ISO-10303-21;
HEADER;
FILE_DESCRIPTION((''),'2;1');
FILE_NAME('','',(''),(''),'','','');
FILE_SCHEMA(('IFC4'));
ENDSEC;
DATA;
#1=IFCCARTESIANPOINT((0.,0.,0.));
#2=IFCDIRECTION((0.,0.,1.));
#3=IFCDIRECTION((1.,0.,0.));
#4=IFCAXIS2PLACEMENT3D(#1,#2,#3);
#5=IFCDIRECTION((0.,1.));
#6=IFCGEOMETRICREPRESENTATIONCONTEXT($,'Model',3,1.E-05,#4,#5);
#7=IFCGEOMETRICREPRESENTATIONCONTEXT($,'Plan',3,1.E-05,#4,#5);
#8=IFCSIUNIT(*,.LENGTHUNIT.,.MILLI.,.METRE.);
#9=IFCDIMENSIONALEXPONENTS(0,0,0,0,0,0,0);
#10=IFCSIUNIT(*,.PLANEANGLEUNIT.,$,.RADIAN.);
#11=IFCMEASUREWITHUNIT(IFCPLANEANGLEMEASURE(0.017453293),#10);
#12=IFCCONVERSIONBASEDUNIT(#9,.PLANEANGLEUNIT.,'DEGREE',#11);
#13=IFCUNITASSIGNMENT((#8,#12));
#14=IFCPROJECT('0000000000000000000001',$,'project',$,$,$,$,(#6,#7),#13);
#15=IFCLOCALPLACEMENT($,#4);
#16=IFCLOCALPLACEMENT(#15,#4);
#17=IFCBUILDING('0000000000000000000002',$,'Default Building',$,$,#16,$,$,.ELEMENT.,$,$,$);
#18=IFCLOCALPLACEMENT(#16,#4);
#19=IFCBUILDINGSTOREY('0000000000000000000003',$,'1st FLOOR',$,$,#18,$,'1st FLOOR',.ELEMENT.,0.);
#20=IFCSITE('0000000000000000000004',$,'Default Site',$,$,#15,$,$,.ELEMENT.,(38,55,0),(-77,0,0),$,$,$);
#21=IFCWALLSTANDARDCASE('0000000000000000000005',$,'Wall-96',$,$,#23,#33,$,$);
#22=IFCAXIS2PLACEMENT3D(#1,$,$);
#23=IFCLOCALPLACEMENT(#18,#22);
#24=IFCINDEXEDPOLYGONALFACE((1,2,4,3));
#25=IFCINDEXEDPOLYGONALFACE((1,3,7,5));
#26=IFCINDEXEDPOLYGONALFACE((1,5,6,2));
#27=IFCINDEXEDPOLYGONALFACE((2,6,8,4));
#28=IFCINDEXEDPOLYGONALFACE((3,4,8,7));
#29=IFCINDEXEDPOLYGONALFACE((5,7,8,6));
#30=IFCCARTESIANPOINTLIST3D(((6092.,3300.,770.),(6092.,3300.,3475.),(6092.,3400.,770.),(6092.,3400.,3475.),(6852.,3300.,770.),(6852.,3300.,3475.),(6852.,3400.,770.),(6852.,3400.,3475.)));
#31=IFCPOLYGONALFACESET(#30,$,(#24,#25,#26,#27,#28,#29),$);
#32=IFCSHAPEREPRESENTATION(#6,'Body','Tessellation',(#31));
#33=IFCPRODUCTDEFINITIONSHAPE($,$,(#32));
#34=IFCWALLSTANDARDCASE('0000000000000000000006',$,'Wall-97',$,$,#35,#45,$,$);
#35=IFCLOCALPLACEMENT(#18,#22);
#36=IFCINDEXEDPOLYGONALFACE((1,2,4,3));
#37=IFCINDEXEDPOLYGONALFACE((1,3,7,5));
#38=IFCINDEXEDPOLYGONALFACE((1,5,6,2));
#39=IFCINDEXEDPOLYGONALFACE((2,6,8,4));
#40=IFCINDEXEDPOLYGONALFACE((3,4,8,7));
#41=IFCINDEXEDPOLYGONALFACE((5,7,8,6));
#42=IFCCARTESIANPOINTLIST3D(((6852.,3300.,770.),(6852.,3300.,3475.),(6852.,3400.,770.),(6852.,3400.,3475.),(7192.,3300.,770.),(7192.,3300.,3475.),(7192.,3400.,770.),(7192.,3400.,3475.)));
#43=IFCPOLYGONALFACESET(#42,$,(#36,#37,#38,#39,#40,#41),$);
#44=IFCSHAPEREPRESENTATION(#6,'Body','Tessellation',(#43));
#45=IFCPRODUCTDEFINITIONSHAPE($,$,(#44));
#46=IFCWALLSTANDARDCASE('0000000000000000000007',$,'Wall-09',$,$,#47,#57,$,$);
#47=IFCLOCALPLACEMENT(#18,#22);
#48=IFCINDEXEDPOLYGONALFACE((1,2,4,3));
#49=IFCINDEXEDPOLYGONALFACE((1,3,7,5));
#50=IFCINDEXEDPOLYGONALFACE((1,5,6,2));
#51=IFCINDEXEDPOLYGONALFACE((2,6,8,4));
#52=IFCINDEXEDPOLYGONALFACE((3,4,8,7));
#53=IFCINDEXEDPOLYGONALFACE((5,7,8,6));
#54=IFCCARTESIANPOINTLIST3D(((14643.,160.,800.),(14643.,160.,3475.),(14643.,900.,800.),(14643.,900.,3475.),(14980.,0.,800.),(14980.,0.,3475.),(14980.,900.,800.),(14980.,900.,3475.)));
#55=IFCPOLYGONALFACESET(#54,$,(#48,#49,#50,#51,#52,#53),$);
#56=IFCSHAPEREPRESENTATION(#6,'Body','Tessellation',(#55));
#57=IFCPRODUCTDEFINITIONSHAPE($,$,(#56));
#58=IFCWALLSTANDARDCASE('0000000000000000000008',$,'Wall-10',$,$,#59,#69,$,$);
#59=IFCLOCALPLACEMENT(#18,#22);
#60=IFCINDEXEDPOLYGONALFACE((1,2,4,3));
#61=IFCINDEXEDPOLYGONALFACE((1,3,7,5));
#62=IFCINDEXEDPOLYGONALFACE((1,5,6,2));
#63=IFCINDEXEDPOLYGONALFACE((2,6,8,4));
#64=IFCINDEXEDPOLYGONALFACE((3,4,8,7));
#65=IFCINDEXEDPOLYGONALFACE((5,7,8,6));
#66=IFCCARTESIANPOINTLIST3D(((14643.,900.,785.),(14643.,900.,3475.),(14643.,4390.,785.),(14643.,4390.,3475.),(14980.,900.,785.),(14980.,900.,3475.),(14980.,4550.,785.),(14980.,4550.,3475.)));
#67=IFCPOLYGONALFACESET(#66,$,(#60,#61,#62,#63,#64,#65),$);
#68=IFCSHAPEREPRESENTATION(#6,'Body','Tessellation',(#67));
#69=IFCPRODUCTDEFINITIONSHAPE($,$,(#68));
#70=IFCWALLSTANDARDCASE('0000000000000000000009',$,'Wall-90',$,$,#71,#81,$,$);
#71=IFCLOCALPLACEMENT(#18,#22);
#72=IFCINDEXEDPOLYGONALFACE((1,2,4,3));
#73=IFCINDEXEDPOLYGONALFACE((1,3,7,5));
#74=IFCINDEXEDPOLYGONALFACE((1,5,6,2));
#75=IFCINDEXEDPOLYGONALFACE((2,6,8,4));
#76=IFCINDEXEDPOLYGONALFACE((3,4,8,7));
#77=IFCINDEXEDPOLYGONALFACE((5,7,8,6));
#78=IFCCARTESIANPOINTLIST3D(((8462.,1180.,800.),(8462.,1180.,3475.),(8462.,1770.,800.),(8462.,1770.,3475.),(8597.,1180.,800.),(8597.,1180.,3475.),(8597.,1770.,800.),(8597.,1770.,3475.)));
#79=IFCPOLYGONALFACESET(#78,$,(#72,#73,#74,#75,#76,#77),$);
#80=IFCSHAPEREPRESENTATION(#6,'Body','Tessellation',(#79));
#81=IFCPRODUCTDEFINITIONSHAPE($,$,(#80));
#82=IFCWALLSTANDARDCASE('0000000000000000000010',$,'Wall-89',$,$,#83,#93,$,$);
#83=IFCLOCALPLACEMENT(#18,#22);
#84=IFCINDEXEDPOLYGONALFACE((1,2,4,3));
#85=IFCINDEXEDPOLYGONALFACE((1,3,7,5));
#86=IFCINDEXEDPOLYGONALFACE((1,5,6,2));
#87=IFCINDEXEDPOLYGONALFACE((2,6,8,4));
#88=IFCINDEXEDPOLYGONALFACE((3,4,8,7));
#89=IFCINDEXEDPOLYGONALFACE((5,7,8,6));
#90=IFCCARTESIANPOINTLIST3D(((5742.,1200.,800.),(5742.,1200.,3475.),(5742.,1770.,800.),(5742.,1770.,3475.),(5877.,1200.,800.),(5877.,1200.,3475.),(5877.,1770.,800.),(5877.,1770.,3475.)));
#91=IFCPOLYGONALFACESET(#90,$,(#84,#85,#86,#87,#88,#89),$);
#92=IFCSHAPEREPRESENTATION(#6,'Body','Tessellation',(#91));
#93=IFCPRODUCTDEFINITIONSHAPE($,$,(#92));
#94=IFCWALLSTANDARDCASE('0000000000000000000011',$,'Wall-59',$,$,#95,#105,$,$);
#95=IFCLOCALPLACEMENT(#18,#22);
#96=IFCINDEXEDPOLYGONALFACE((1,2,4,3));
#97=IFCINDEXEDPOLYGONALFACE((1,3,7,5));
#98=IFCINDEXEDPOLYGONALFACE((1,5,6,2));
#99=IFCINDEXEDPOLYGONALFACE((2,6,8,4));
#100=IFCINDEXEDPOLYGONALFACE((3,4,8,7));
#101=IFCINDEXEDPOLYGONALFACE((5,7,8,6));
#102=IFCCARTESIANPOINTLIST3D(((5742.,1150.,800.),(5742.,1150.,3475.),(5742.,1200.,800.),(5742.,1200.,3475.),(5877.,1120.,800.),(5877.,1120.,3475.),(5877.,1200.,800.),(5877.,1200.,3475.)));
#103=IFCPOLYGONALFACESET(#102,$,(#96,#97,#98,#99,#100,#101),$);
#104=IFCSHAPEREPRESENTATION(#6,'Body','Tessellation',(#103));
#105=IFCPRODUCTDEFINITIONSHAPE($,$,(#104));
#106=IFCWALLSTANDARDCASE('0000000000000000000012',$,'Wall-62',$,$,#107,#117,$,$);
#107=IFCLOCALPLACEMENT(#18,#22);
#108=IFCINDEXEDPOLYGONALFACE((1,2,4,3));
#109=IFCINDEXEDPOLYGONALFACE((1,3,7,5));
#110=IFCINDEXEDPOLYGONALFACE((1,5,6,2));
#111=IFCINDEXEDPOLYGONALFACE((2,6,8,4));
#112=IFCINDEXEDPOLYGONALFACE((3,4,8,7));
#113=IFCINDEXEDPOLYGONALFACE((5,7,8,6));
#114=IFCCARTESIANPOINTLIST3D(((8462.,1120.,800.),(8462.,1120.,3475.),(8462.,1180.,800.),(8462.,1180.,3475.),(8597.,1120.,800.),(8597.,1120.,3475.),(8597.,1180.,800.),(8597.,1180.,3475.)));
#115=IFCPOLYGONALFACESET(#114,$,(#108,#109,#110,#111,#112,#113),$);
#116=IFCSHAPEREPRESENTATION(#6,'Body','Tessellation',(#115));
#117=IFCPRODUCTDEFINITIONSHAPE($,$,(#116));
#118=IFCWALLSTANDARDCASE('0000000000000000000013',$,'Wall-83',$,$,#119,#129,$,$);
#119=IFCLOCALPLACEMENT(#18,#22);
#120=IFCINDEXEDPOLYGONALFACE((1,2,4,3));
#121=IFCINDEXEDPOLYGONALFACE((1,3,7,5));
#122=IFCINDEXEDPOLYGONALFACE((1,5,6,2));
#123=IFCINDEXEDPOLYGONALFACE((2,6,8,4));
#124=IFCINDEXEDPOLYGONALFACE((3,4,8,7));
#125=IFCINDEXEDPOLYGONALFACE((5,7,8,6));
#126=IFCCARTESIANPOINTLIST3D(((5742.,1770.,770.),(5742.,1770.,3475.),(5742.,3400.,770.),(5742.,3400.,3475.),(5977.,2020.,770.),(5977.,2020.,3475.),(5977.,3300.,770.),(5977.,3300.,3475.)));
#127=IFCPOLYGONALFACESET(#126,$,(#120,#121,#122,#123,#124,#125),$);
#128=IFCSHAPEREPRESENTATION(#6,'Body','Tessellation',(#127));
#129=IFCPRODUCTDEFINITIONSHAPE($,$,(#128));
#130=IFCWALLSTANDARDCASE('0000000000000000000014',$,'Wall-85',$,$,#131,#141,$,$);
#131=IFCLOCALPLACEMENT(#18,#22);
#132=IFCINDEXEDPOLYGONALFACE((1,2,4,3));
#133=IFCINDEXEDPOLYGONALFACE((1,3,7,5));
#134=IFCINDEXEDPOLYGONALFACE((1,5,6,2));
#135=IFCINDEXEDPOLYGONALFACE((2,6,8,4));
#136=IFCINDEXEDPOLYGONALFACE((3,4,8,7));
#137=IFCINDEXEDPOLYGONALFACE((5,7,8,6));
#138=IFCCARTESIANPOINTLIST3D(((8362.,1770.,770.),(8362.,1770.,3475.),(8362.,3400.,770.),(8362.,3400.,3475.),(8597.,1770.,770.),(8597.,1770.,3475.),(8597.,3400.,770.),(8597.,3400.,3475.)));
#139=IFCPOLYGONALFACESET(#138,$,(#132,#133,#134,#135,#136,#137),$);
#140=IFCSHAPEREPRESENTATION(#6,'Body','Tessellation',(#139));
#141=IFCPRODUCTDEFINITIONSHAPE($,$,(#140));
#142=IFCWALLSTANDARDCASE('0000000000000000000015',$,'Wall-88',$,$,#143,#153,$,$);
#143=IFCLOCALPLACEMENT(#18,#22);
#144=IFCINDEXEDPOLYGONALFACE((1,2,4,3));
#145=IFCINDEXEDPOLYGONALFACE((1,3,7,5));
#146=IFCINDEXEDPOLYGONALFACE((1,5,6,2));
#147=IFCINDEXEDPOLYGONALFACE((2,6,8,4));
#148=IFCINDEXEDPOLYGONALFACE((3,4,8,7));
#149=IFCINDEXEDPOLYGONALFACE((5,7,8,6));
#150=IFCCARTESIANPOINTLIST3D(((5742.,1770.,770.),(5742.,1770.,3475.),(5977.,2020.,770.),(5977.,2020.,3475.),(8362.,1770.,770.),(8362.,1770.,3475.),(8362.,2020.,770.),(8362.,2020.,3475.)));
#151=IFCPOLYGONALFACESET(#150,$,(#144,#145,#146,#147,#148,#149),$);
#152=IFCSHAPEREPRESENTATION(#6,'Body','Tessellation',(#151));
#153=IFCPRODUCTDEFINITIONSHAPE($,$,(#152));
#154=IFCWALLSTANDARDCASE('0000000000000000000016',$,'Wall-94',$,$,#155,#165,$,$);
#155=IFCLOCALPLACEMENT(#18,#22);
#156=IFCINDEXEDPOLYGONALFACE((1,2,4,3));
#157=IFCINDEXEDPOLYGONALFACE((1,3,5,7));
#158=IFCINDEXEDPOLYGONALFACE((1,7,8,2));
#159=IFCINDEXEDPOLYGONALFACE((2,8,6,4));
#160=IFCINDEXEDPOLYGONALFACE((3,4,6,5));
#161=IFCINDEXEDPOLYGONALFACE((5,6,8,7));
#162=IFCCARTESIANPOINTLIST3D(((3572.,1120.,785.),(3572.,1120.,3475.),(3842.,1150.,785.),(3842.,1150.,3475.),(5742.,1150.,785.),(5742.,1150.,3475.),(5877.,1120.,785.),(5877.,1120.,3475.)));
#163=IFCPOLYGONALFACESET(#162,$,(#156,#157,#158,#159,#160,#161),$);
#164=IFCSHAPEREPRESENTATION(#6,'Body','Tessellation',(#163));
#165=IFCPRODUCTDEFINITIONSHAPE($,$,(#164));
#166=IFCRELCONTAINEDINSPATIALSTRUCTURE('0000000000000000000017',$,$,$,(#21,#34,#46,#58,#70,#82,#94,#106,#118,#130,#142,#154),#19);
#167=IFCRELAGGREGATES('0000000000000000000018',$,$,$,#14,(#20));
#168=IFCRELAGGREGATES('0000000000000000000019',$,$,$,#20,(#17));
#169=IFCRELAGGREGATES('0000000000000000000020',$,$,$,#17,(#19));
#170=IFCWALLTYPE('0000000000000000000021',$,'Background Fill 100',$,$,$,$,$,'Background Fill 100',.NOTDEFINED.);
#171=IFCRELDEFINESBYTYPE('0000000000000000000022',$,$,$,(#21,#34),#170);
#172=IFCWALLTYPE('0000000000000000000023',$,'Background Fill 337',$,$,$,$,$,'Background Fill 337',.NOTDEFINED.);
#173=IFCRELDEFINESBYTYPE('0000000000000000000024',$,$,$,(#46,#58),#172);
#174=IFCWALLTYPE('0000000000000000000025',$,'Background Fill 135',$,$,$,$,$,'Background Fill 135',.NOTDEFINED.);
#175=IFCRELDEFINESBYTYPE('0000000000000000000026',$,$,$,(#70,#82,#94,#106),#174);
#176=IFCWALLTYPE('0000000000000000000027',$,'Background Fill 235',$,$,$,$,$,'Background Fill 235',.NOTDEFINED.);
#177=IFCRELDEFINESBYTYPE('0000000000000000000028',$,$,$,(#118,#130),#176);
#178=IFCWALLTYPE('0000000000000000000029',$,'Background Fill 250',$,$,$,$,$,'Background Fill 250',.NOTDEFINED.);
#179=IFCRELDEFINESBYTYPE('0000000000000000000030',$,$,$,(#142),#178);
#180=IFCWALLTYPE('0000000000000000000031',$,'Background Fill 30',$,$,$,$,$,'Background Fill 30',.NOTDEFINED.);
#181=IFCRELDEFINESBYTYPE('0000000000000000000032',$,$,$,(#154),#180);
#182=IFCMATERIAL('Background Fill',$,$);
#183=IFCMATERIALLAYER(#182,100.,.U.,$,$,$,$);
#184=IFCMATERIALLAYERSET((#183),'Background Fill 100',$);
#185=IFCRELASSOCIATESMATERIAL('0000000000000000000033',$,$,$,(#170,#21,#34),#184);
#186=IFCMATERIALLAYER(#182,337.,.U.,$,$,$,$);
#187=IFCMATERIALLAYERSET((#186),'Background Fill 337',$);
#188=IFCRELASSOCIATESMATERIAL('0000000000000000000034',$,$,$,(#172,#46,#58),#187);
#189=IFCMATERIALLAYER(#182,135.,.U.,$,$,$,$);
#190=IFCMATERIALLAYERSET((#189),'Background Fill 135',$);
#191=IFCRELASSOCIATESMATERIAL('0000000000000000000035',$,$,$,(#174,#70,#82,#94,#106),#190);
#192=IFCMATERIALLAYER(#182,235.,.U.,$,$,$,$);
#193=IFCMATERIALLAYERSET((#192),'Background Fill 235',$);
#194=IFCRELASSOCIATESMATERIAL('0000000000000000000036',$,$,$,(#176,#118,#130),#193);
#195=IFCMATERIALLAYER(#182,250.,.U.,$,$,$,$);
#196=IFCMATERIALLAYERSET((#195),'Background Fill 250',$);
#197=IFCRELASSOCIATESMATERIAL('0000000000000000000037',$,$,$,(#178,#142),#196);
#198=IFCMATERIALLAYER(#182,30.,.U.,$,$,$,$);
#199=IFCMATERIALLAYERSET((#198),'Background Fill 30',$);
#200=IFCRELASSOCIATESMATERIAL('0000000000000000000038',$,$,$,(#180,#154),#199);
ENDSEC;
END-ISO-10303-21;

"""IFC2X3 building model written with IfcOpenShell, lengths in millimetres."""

from ifc_helpers import new_model, entity, si_unit, converted_unit, direction, frame, origin_with_axes, place, context, project, spatial, polyline, outline, extrude, material, layer, layer_set, layer_usage, type_object, element, save


model = new_model("IFC2X3")

# Units and contexts
model_context = context("Model", 3, precision=1e-05, world=origin_with_axes(), true_north=direction((0.0, 1.0)))
plan_context = context("Plan", 3, precision=1e-05, world=origin_with_axes(), true_north=direction((0.0, 1.0)))
ifc_project = project(units=[si_unit("LENGTHUNIT", "METRE", prefix="MILLI"), converted_unit("PLANEANGLEUNIT", "DEGREE", entity("IfcPlaneAngleMeasure", 0.017453293), si_unit("PLANEANGLEUNIT", "RADIAN"), dimensions=[0, 0, 0, 0, 0, 0, 0])], contexts=[model_context, plan_context])

# Site, building, storey
site_placement = place(None, origin_with_axes())
site = spatial("IfcSite", under=ifc_project, at=site_placement, Name="Default Site", CompositionType="ELEMENT", RefLatitude=(38, 55, 0), RefLongitude=(-77, 0, 0))
building_placement = place(site_placement, origin_with_axes())
building = spatial("IfcBuilding", under=site, at=building_placement, Name="Default Building", CompositionType="ELEMENT")
storey_placement = place(building_placement, origin_with_axes())
storey = spatial("IfcBuildingStorey", under=building, at=storey_placement, Name="1st FLOOR", LongName="1st FLOOR", CompositionType="ELEMENT", Elevation=0.0)

# Shared definitions
ifc_material = material(Name="Background Fill")

# Walls
ifc_layer_1 = layer(ifc_material, 100.0, ventilated="UNKNOWN")
ifc_layer_set_1 = layer_set([ifc_layer_1], Name="Background Fill 100")
wall_type_1 = type_object("IfcWallType", Name="Background Fill 100", ElementType="Background Fill 100", PredefinedType="NOTDEFINED", material=ifc_layer_set_1)
ifc_layer_usage_1 = layer_usage(ifc_layer_set_1, "AXIS2", "NEGATIVE", 0.0)
wall_1_placement = place(storey_placement, frame((6092.0, 3400.0, 770.0), z_axis=(0.0, 0.0, 1.0), x_axis=(1.0, 0.0, 0.0)))
element("IfcWallStandardCase", 1, at=wall_1_placement, inside=storey, type_object=wall_type_1, material=ifc_layer_usage_1, Name="Wall-96", context=model_context, shape_type="SweptSolid", body=[
    extrude(outline(polyline([(0.0, -100.0), (760.0, -100.0), (760.0, 0.0), (0.0, 0.0), (0.0, -100.0)])), origin_with_axes(), (0.0, 0.0, 1.0), 2705.0),
])
ifc_layer_usage_2 = layer_usage(ifc_layer_set_1, "AXIS2", "NEGATIVE", 0.0)
wall_2_placement = place(storey_placement, frame((6852.0, 3400.0, 770.0), z_axis=(0.0, 0.0, 1.0), x_axis=(1.0, 0.0, 0.0)))
element("IfcWallStandardCase", 2, at=wall_2_placement, inside=storey, type_object=wall_type_1, material=ifc_layer_usage_2, Name="Wall-97", context=model_context, shape_type="SweptSolid", body=[
    extrude(outline(polyline([(0.0, -100.0), (340.0, -100.0), (340.0, 0.0), (0.0, 0.0), (0.0, -100.0)])), origin_with_axes(), (0.0, 0.0, 1.0), 2705.0),
])
ifc_layer_2 = layer(ifc_material, 337.0, ventilated="UNKNOWN")
ifc_layer_set_2 = layer_set([ifc_layer_2], Name="Background Fill 337")
ifc_layer_usage_3 = layer_usage(ifc_layer_set_2, "AXIS2", "NEGATIVE", 0.0)
wall_type_2 = type_object("IfcWallType", Name="Background Fill 337", ElementType="Background Fill 337", PredefinedType="NOTDEFINED", material=ifc_layer_set_2)
wall_3_placement = place(storey_placement, frame((14643.0, 0.0, 800.0), z_axis=(0.0, 0.0, 1.0), x_axis=(0.0, 1.0, 0.0)))
element("IfcWallStandardCase", 3, at=wall_3_placement, inside=storey, type_object=wall_type_2, material=ifc_layer_usage_3, Name="Wall-09", context=model_context, shape_type="SweptSolid", body=[
    extrude(outline(polyline([(0.0, -337.0), (900.0, -337.0), (900.0, 0.0), (160.0, 0.0), (0.0, -337.0)])), origin_with_axes(), (0.0, 0.0, 1.0), 2675.0),
])
ifc_layer_usage_4 = layer_usage(ifc_layer_set_2, "AXIS2", "NEGATIVE", 0.0)
wall_4_placement = place(storey_placement, frame((14643.0, 900.0, 785.0), z_axis=(0.0, 0.0, 1.0), x_axis=(0.0, 1.0, 0.0)))
element("IfcWallStandardCase", 4, at=wall_4_placement, inside=storey, type_object=wall_type_2, material=ifc_layer_usage_4, Name="Wall-10", context=model_context, shape_type="SweptSolid", body=[
    extrude(outline(polyline([(0.0, -337.0), (3650.0, -337.0), (3490.0, 0.0), (0.0, 0.0), (0.0, -337.0)])), origin_with_axes(), (0.0, 0.0, 1.0), 2690.0),
])
ifc_layer_3 = layer(ifc_material, 135.0, ventilated="UNKNOWN")
ifc_layer_set_3 = layer_set([ifc_layer_3], Name="Background Fill 135")
ifc_layer_usage_5 = layer_usage(ifc_layer_set_3, "AXIS2", "NEGATIVE", 0.0)
wall_type_3 = type_object("IfcWallType", Name="Background Fill 135", ElementType="Background Fill 135", PredefinedType="NOTDEFINED", material=ifc_layer_set_3)
wall_5_placement = place(storey_placement, frame((8462.0, 1180.0, 800.0), z_axis=(0.0, 0.0, 1.0), x_axis=(0.0, 1.0, 0.0)))
element("IfcWallStandardCase", 5, at=wall_5_placement, inside=storey, type_object=wall_type_3, material=ifc_layer_usage_5, Name="Wall-90", context=model_context, shape_type="SweptSolid", body=[
    extrude(outline(polyline([(0.0, -135.0), (590.0, -135.0), (590.0, 0.0), (0.0, 0.0), (0.0, -135.0)])), origin_with_axes(), (0.0, 0.0, 1.0), 2675.0),
])
ifc_layer_usage_6 = layer_usage(ifc_layer_set_3, "AXIS2", "NEGATIVE", 0.0)
wall_6_placement = place(storey_placement, frame((5742.0, 1200.0, 800.0), z_axis=(0.0, 0.0, 1.0), x_axis=(0.0, 1.0, 0.0)))
element("IfcWallStandardCase", 6, at=wall_6_placement, inside=storey, type_object=wall_type_3, material=ifc_layer_usage_6, Name="Wall-89", context=model_context, shape_type="SweptSolid", body=[
    extrude(outline(polyline([(0.0, -135.0), (570.0, -135.0), (570.0, 0.0), (0.0, 0.0), (0.0, -135.0)])), origin_with_axes(), (0.0, 0.0, 1.0), 2675.0),
])
ifc_layer_usage_7 = layer_usage(ifc_layer_set_3, "AXIS2", "NEGATIVE", 0.0)
wall_7_placement = place(storey_placement, frame((5742.0, 1120.0, 800.0), z_axis=(0.0, 0.0, 1.0), x_axis=(0.0, 1.0, 0.0)))
element("IfcWallStandardCase", 7, at=wall_7_placement, inside=storey, type_object=wall_type_3, material=ifc_layer_usage_7, Name="Wall-59", context=model_context, shape_type="SweptSolid", body=[
    extrude(outline(polyline([(0.0, -135.0), (80.0, -135.0), (80.0, 0.0), (30.0, 0.0), (0.0, -135.0)])), origin_with_axes(), (0.0, 0.0, 1.0), 2675.0),
])
ifc_layer_usage_8 = layer_usage(ifc_layer_set_3, "AXIS2", "POSITIVE", 0.0)
wall_8_placement = place(storey_placement, frame((8597.0, 1120.0, 800.0), z_axis=(0.0, 0.0, 1.0), x_axis=(0.0, 1.0, 0.0)))
element("IfcWallStandardCase", 8, at=wall_8_placement, inside=storey, type_object=wall_type_3, material=ifc_layer_usage_8, Name="Wall-62", context=model_context, shape_type="SweptSolid", body=[
    extrude(outline(polyline([(0.0, 0.0), (60.0, 0.0), (60.0, 135.0), (0.0, 135.0), (0.0, 0.0)])), origin_with_axes(), (0.0, 0.0, 1.0), 2675.0),
])
ifc_layer_4 = layer(ifc_material, 235.0, ventilated="UNKNOWN")
ifc_layer_set_4 = layer_set([ifc_layer_4], Name="Background Fill 235")
ifc_layer_usage_9 = layer_usage(ifc_layer_set_4, "AXIS2", "NEGATIVE", 0.0)
wall_type_4 = type_object("IfcWallType", Name="Background Fill 235", ElementType="Background Fill 235", PredefinedType="NOTDEFINED", material=ifc_layer_set_4)
wall_9_placement = place(storey_placement, frame((5742.0, 1770.0, 770.0), z_axis=(0.0, 0.0, 1.0), x_axis=(0.0, 1.0, 0.0)))
element("IfcWallStandardCase", 9, at=wall_9_placement, inside=storey, type_object=wall_type_4, material=ifc_layer_usage_9, Name="Wall-83", context=model_context, shape_type="SweptSolid", body=[
    extrude(outline(polyline([(250.0, -235.0), (1530.0, -235.0), (1630.0, 0.0), (0.0, 0.0), (250.0, -235.0)])), origin_with_axes(), (0.0, 0.0, 1.0), 2705.0),
])
ifc_layer_usage_10 = layer_usage(ifc_layer_set_4, "AXIS2", "POSITIVE", 0.0)
wall_10_placement = place(storey_placement, frame((8597.0, 1770.0, 770.0), z_axis=(0.0, 0.0, 1.0), x_axis=(0.0, 1.0, 0.0)))
element("IfcWallStandardCase", 10, at=wall_10_placement, inside=storey, type_object=wall_type_4, material=ifc_layer_usage_10, Name="Wall-85", context=model_context, shape_type="SweptSolid", body=[
    extrude(outline(polyline([(0.0, 0.0), (1630.0, 0.0), (1630.0, 235.0), (0.0, 235.0), (0.0, 0.0)])), origin_with_axes(), (0.0, 0.0, 1.0), 2705.0),
])
ifc_layer_5 = layer(ifc_material, 250.0, ventilated="UNKNOWN")
ifc_layer_set_5 = layer_set([ifc_layer_5], Name="Background Fill 250")
ifc_layer_usage_11 = layer_usage(ifc_layer_set_5, "AXIS2", "NEGATIVE", 0.0)
wall_type_5 = type_object("IfcWallType", Name="Background Fill 250", ElementType="Background Fill 250", PredefinedType="NOTDEFINED", material=ifc_layer_set_5)
wall_11_placement = place(storey_placement, frame((8362.0, 1770.0, 770.0), z_axis=(0.0, 0.0, 1.0), x_axis=(-1.0, 0.0, 0.0)))
element("IfcWallStandardCase", 11, at=wall_11_placement, inside=storey, type_object=wall_type_5, material=ifc_layer_usage_11, Name="Wall-88", context=model_context, shape_type="SweptSolid", body=[
    extrude(outline(polyline([(0.0, -250.0), (2385.0, -250.0), (2620.0, 0.0), (0.0, 0.0), (0.0, -250.0)])), origin_with_axes(), (0.0, 0.0, 1.0), 2705.0),
])
ifc_layer_6 = layer(ifc_material, 30.0, ventilated="UNKNOWN")
ifc_layer_set_6 = layer_set([ifc_layer_6], Name="Background Fill 30")
ifc_layer_usage_12 = layer_usage(ifc_layer_set_6, "AXIS2", "NEGATIVE", 0.0)
wall_type_6 = type_object("IfcWallType", Name="Background Fill 30", ElementType="Background Fill 30", PredefinedType="NOTDEFINED", material=ifc_layer_set_6)
wall_12_placement = place(storey_placement, frame((5742.0, 1120.0, 785.0), z_axis=(0.0, 0.0, 1.0), x_axis=(-1.0, 0.0, 0.0)))
element("IfcWallStandardCase", 12, at=wall_12_placement, inside=storey, type_object=wall_type_6, material=ifc_layer_usage_12, Name="Wall-94", context=model_context, shape_type="SweptSolid", body=[
    extrude(outline(polyline([(0.0, -30.0), (1900.0, -30.0), (2170.0, 0.0), (-135.0, 0.0), (0.0, -30.0)])), origin_with_axes(), (0.0, 0.0, 1.0), 2690.0),
])

save(model, "model.ifc")
